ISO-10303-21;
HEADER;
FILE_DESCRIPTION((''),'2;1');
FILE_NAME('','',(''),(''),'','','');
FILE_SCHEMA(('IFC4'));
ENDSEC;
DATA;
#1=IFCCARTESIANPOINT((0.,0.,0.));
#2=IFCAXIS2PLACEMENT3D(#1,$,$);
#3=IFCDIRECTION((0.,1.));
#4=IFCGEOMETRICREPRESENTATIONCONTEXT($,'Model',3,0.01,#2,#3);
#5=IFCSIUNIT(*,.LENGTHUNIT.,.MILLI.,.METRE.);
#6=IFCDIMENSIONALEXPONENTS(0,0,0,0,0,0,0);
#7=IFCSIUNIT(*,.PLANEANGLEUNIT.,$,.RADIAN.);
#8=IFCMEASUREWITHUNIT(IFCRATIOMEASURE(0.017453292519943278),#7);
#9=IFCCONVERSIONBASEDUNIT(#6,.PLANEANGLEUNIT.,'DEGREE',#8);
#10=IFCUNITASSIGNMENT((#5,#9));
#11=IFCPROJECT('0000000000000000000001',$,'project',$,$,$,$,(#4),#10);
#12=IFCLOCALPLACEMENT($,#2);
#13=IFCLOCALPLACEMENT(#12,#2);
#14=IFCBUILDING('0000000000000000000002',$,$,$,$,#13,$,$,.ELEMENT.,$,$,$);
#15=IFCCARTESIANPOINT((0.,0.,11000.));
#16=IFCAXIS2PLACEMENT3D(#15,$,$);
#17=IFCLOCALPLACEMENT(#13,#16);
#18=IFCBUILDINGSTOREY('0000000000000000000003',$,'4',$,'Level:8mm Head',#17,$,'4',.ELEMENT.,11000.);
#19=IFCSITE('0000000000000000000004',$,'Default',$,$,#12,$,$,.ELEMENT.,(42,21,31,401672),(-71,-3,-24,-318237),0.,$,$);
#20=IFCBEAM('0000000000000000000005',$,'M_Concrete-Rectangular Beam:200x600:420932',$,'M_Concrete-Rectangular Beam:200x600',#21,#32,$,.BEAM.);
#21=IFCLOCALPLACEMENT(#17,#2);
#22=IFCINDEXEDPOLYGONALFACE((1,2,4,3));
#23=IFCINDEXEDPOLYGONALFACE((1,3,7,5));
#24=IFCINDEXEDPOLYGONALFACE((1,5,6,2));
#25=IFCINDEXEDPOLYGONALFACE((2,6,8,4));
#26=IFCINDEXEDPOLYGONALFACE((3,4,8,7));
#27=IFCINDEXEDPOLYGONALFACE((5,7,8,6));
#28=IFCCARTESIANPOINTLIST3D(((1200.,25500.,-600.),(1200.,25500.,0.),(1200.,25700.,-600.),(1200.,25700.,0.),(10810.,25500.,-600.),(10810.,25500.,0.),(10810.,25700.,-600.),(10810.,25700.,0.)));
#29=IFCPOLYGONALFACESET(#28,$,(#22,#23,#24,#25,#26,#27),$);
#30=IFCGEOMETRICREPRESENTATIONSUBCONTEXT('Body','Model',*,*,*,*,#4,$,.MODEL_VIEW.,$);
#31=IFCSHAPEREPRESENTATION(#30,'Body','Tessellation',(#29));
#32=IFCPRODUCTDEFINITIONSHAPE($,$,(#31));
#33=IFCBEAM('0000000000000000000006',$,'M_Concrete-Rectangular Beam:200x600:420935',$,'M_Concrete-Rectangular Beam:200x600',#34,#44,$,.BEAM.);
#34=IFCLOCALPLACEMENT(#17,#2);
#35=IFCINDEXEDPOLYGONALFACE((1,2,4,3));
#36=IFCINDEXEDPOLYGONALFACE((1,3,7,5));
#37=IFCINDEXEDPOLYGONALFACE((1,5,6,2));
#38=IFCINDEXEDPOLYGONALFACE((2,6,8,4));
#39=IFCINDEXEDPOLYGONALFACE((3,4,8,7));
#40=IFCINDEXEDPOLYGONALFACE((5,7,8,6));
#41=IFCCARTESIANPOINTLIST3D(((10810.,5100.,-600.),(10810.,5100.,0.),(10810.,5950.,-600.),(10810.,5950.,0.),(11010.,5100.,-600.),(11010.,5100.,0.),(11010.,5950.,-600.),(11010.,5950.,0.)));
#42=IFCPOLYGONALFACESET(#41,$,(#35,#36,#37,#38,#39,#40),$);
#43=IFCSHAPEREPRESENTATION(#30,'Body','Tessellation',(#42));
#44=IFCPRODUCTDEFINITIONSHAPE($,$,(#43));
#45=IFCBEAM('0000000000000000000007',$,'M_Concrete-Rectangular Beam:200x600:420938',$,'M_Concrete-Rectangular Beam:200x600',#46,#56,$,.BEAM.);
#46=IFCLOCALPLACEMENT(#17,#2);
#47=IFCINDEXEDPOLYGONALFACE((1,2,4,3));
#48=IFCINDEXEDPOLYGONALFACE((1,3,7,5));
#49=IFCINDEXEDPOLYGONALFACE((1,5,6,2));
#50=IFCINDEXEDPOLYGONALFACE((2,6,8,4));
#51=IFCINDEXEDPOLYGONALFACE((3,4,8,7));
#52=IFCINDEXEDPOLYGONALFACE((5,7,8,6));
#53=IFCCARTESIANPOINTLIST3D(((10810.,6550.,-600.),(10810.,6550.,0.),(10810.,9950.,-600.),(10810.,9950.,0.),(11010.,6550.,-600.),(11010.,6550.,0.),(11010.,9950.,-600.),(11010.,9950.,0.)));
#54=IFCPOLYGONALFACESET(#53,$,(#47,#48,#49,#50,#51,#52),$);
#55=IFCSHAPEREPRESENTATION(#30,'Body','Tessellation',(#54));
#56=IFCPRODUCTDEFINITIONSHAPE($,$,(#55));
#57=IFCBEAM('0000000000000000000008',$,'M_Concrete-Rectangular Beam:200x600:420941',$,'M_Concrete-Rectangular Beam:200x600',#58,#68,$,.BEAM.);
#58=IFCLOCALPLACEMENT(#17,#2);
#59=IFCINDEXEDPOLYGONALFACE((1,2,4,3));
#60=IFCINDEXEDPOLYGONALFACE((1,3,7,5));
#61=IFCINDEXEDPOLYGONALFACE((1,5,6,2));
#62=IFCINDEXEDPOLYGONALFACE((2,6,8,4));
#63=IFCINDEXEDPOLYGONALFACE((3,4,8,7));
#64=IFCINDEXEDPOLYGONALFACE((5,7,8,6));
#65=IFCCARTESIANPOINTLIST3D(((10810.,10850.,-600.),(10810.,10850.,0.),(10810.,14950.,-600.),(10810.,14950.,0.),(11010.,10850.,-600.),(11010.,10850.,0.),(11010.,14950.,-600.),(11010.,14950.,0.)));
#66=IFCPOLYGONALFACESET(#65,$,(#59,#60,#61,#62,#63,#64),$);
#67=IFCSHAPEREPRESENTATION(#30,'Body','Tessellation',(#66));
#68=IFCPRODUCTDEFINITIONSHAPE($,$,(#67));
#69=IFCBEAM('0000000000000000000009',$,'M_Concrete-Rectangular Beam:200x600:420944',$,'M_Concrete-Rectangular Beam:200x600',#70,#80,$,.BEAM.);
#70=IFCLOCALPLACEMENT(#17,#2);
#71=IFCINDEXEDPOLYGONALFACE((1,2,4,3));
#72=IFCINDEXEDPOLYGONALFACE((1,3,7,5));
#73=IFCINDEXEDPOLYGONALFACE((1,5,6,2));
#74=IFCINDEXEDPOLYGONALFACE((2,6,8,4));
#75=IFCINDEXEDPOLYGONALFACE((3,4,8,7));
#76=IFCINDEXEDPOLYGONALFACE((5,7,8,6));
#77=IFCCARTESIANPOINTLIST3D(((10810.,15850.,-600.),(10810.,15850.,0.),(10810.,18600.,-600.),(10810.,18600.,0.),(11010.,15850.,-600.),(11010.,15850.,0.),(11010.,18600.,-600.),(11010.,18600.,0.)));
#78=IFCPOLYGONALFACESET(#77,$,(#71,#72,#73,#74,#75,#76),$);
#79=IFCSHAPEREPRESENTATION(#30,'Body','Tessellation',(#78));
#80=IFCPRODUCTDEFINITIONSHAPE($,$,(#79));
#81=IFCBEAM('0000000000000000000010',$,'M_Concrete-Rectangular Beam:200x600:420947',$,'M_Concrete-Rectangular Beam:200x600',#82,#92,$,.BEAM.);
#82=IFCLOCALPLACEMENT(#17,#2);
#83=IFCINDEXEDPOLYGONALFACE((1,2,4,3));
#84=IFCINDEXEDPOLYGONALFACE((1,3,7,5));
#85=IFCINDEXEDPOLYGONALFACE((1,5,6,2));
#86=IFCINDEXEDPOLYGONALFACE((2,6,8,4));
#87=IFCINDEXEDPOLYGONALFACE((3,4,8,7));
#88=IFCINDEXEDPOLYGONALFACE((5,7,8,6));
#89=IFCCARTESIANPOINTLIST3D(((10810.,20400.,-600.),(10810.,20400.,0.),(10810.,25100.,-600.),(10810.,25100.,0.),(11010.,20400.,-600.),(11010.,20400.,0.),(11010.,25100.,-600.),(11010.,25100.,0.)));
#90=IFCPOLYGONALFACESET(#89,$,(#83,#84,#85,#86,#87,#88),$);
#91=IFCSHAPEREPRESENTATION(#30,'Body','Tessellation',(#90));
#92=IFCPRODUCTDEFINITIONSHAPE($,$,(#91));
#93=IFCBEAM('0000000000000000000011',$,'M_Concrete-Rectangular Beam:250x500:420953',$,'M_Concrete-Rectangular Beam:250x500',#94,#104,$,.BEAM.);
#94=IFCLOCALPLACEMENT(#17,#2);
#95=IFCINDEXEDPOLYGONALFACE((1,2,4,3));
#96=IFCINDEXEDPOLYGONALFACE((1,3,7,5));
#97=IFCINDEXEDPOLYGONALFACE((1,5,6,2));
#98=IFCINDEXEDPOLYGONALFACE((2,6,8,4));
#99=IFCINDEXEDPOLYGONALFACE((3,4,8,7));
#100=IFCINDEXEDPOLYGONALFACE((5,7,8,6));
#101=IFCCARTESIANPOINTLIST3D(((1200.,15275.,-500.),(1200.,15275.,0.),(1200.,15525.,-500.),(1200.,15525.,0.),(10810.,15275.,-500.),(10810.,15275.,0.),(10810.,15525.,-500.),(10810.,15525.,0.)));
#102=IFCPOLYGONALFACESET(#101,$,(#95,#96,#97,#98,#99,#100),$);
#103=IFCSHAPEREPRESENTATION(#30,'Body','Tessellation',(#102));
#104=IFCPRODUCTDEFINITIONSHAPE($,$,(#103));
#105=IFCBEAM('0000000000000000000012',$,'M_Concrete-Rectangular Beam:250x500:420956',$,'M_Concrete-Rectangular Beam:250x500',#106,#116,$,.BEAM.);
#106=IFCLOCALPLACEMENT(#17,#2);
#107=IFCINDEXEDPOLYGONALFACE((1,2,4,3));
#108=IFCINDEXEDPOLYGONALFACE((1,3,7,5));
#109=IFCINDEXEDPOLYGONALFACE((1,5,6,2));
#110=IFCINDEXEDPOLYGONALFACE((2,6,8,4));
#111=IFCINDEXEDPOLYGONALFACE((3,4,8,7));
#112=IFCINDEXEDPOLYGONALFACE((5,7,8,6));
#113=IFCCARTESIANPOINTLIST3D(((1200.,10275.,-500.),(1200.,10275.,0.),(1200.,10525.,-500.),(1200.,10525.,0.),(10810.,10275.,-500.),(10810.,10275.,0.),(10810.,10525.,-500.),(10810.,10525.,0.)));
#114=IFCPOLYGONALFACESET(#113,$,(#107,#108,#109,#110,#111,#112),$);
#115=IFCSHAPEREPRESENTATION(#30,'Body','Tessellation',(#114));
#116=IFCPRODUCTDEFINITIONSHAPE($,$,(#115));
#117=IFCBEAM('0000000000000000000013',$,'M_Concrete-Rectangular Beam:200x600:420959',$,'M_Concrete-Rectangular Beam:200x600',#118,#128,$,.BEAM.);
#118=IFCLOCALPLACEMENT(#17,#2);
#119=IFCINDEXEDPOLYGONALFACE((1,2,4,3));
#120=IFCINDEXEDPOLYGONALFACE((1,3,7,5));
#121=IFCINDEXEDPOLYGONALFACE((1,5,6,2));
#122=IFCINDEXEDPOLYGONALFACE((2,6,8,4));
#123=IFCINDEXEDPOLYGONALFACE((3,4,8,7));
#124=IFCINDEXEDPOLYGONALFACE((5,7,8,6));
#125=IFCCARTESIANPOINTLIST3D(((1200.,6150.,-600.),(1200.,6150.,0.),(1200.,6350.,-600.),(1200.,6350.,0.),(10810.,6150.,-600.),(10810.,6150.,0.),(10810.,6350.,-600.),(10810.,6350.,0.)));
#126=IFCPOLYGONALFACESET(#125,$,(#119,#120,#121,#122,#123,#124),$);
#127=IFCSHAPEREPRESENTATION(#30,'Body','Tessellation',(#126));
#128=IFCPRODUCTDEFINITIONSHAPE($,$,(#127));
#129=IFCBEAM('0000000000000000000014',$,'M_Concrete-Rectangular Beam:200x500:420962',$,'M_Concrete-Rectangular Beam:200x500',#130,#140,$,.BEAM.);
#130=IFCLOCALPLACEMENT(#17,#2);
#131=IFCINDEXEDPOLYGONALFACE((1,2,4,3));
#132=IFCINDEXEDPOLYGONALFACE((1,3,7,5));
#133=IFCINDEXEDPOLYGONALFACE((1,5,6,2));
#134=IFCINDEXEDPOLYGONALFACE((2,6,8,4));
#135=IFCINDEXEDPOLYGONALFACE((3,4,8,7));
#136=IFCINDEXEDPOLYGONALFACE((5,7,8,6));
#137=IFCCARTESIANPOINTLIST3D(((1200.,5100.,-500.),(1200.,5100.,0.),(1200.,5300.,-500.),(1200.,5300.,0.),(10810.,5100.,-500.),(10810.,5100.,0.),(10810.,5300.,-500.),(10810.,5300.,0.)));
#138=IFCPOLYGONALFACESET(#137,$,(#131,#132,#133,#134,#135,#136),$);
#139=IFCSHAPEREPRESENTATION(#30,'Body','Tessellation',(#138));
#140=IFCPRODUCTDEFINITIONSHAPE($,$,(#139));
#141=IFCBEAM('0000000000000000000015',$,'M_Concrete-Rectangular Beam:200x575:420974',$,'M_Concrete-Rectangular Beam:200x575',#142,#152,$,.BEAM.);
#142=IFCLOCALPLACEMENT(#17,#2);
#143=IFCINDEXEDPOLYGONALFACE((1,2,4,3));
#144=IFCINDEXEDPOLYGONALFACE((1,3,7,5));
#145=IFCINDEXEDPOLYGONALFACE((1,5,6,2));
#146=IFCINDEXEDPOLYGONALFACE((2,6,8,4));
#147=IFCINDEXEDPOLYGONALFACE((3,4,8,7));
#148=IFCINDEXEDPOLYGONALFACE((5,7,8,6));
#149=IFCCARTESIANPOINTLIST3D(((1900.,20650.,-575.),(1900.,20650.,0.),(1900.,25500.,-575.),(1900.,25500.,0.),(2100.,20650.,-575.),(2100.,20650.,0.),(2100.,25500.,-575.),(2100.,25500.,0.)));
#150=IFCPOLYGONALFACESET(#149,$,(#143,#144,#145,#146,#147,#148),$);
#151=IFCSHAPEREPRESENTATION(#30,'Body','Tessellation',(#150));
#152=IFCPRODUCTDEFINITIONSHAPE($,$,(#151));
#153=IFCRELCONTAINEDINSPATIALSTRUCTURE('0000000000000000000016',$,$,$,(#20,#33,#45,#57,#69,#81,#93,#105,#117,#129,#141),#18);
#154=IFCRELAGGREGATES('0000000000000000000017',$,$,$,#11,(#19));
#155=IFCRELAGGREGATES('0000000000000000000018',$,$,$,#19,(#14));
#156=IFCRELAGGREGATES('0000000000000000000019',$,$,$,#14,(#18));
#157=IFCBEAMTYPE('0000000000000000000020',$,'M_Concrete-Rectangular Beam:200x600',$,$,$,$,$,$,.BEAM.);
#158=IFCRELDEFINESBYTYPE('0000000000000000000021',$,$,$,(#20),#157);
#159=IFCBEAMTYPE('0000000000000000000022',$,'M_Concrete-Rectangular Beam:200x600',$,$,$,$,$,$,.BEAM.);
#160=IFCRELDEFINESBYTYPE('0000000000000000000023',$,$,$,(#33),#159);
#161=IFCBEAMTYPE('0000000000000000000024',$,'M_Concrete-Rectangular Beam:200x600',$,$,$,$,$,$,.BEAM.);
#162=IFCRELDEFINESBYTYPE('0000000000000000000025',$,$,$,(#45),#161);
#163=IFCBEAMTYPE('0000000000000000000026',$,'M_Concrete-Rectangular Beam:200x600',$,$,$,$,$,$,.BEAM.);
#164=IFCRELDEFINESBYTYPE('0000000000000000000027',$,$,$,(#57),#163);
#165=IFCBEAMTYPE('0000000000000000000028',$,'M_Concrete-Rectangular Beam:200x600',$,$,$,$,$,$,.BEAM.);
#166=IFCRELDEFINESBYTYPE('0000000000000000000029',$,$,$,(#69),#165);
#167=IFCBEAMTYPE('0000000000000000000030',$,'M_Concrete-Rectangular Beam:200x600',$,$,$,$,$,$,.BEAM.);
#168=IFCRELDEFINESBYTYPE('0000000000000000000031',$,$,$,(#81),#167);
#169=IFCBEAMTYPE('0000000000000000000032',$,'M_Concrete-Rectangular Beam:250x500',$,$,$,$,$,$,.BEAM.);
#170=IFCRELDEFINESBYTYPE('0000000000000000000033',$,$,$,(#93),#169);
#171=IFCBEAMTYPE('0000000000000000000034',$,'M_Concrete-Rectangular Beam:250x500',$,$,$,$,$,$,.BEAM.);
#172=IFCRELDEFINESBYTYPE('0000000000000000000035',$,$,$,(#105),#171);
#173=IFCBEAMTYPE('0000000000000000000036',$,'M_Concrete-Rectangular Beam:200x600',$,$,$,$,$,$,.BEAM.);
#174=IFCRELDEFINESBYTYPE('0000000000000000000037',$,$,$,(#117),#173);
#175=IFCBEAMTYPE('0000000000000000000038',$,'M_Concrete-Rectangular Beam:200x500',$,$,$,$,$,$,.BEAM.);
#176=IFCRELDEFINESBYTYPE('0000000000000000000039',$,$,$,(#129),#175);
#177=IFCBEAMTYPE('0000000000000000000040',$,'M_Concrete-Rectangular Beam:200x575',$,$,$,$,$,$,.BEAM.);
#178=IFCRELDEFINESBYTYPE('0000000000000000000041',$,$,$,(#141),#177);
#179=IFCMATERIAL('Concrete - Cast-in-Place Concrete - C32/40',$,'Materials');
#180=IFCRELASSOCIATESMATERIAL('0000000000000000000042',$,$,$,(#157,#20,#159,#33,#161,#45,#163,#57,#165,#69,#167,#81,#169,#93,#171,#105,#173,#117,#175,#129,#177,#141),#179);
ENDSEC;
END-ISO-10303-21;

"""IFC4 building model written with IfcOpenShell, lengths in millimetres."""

from ifc_helpers import new_model, entity, si_unit, converted_unit, direction, frame, origin, place, context, subcontext, project, spatial, indexed_curve, outline, extrude, source, transform, mapped, material, type_object, type_shapes, element, save


model = new_model("IFC4")

# Units and contexts
model_context = context("Model", 3, precision=0.01, world=origin(), true_north=direction((0.0, 1.0)))
body_context = subcontext(model_context, "Body", "Model", "MODEL_VIEW")
ifc_project = project(units=[si_unit("LENGTHUNIT", "METRE", prefix="MILLI"), converted_unit("PLANEANGLEUNIT", "DEGREE", entity("IfcRatioMeasure", 0.017453292519943278), si_unit("PLANEANGLEUNIT", "RADIAN"), dimensions=[0, 0, 0, 0, 0, 0, 0])], contexts=[model_context])

# Site, building, storey
site_placement = place(None, origin())
site = spatial("IfcSite", under=ifc_project, at=site_placement, Name="Default", CompositionType="ELEMENT", RefLatitude=(42, 21, 31, 401672), RefLongitude=(-71, -3, -24, -318237), RefElevation=0.0)
building_placement = place(site_placement, origin())
building = spatial("IfcBuilding", under=site, at=building_placement, CompositionType="ELEMENT")
storey_placement = place(building_placement, frame((0.0, 0.0, 11000.0)))
storey = spatial("IfcBuildingStorey", under=building, at=storey_placement, Name="4", ObjectType="Level:8mm Head", LongName="4", CompositionType="ELEMENT", Elevation=11000.0)

# Beams
ifc_material_1 = material(Name="Concrete - Cast-in-Place Concrete - C32/40", Category="Materials")
beam_type_1 = type_object("IfcBeamType", Name="M_Concrete-Rectangular Beam:200x600", PredefinedType="BEAM", material=ifc_material_1)
shared_shape_1 = source(origin(), body_context, "Body", "SweptSolid", [
    extrude(outline(indexed_curve([(-300.0, -100.0), (300.0, -100.0), (300.0, 100.0), (-300.0, 100.0), (-300.0, -100.0)], self_intersect=False)), frame((1200.0, 25600.0, 10700.0), z_axis=(1.0, 0.0, 0.0), x_axis=(0.0, 0.0, -1.0)), (0.0, 0.0, 1.0), 9610.0),
])
type_shapes(beam_type_1, [shared_shape_1])
beam_1_placement = place(storey_placement, frame((0.0, 0.0, -11000.0)))
element("IfcBeam", 1, at=beam_1_placement, inside=storey, type_object=beam_type_1, material=ifc_material_1, Name="M_Concrete-Rectangular Beam:200x600:420932", ObjectType="M_Concrete-Rectangular Beam:200x600", PredefinedType="BEAM", context=body_context, shape_type="MappedRepresentation", body=[
    mapped(shared_shape_1, transform((0.0, 0.0, 0.0), scale=1.0)),
])
beam_type_2 = type_object("IfcBeamType", Name="M_Concrete-Rectangular Beam:200x600", PredefinedType="BEAM", material=ifc_material_1)
shared_shape_2 = source(origin(), body_context, "Body", "SweptSolid", [
    extrude(outline(indexed_curve([(-100.0, -300.0), (100.0, -300.0), (100.0, 300.0), (-100.0, 300.0), (-100.0, -300.0)], self_intersect=False)), frame((10910.0, 5100.0, 10700.0), z_axis=(0.0, 1.0, 0.0), x_axis=(-1.0, 0.0, 0.0)), (0.0, 0.0, 1.0), 850.0),
])
type_shapes(beam_type_2, [shared_shape_2])
beam_2_placement = place(storey_placement, frame((0.0, 0.0, -11000.0)))
element("IfcBeam", 2, at=beam_2_placement, inside=storey, type_object=beam_type_2, material=ifc_material_1, Name="M_Concrete-Rectangular Beam:200x600:420935", ObjectType="M_Concrete-Rectangular Beam:200x600", PredefinedType="BEAM", context=body_context, shape_type="MappedRepresentation", body=[
    mapped(shared_shape_2, transform((0.0, 0.0, 0.0), scale=1.0)),
])
beam_type_3 = type_object("IfcBeamType", Name="M_Concrete-Rectangular Beam:200x600", PredefinedType="BEAM", material=ifc_material_1)
shared_shape_3 = source(origin(), body_context, "Body", "SweptSolid", [
    extrude(outline(indexed_curve([(-100.0, -300.0), (100.0, -300.0), (100.0, 300.0), (-100.0, 300.0), (-100.0, -300.0)], self_intersect=False)), frame((10910.0, 6550.0, 10700.0), z_axis=(0.0, 1.0, 0.0), x_axis=(-1.0, 0.0, 0.0)), (0.0, 0.0, 1.0), 3400.0),
])
type_shapes(beam_type_3, [shared_shape_3])
beam_3_placement = place(storey_placement, frame((0.0, 0.0, -11000.0)))
element("IfcBeam", 3, at=beam_3_placement, inside=storey, type_object=beam_type_3, material=ifc_material_1, Name="M_Concrete-Rectangular Beam:200x600:420938", ObjectType="M_Concrete-Rectangular Beam:200x600", PredefinedType="BEAM", context=body_context, shape_type="MappedRepresentation", body=[
    mapped(shared_shape_3, transform((0.0, 0.0, 0.0), scale=1.0)),
])
beam_type_4 = type_object("IfcBeamType", Name="M_Concrete-Rectangular Beam:200x600", PredefinedType="BEAM", material=ifc_material_1)
shared_shape_4 = source(origin(), body_context, "Body", "SweptSolid", [
    extrude(outline(indexed_curve([(-100.0, -300.0), (100.0, -300.0), (100.0, 300.0), (-100.0, 300.0), (-100.0, -300.0)], self_intersect=False)), frame((10910.0, 10850.0, 10700.0), z_axis=(0.0, 1.0, 0.0), x_axis=(-1.0, 0.0, 0.0)), (0.0, 0.0, 1.0), 4100.0),
])
type_shapes(beam_type_4, [shared_shape_4])
beam_4_placement = place(storey_placement, frame((0.0, 0.0, -11000.0)))
element("IfcBeam", 4, at=beam_4_placement, inside=storey, type_object=beam_type_4, material=ifc_material_1, Name="M_Concrete-Rectangular Beam:200x600:420941", ObjectType="M_Concrete-Rectangular Beam:200x600", PredefinedType="BEAM", context=body_context, shape_type="MappedRepresentation", body=[
    mapped(shared_shape_4, transform((0.0, 0.0, 0.0), scale=1.0)),
])
beam_type_5 = type_object("IfcBeamType", Name="M_Concrete-Rectangular Beam:200x600", PredefinedType="BEAM", material=ifc_material_1)
shared_shape_5 = source(origin(), body_context, "Body", "SweptSolid", [
    extrude(outline(indexed_curve([(-100.0, -300.0), (100.0, -300.0), (100.0, 300.0), (-100.0, 300.0), (-100.0, -300.0)], self_intersect=False)), frame((10910.0, 15850.0, 10700.0), z_axis=(0.0, 1.0, 0.0), x_axis=(-1.0, 0.0, 0.0)), (0.0, 0.0, 1.0), 2750.0),
])
type_shapes(beam_type_5, [shared_shape_5])
beam_5_placement = place(storey_placement, frame((0.0, 0.0, -11000.0)))
element("IfcBeam", 5, at=beam_5_placement, inside=storey, type_object=beam_type_5, material=ifc_material_1, Name="M_Concrete-Rectangular Beam:200x600:420944", ObjectType="M_Concrete-Rectangular Beam:200x600", PredefinedType="BEAM", context=body_context, shape_type="MappedRepresentation", body=[
    mapped(shared_shape_5, transform((0.0, 0.0, 0.0), scale=1.0)),
])
beam_type_6 = type_object("IfcBeamType", Name="M_Concrete-Rectangular Beam:200x600", PredefinedType="BEAM", material=ifc_material_1)
shared_shape_6 = source(origin(), body_context, "Body", "SweptSolid", [
    extrude(outline(indexed_curve([(-100.0, -300.0), (100.0, -300.0), (100.0, 300.0), (-100.0, 300.0), (-100.0, -300.0)], self_intersect=False)), frame((10910.0, 20400.0, 10700.0), z_axis=(0.0, 1.0, 0.0), x_axis=(-1.0, 0.0, 0.0)), (0.0, 0.0, 1.0), 4700.0),
])
type_shapes(beam_type_6, [shared_shape_6])
beam_6_placement = place(storey_placement, frame((0.0, 0.0, -11000.0)))
element("IfcBeam", 6, at=beam_6_placement, inside=storey, type_object=beam_type_6, material=ifc_material_1, Name="M_Concrete-Rectangular Beam:200x600:420947", ObjectType="M_Concrete-Rectangular Beam:200x600", PredefinedType="BEAM", context=body_context, shape_type="MappedRepresentation", body=[
    mapped(shared_shape_6, transform((0.0, 0.0, 0.0), scale=1.0)),
])
beam_type_7 = type_object("IfcBeamType", Name="M_Concrete-Rectangular Beam:250x500", PredefinedType="BEAM", material=ifc_material_1)
shared_shape_7 = source(origin(), body_context, "Body", "SweptSolid", [
    extrude(outline(indexed_curve([(-250.0, -125.0), (250.0, -125.0), (250.0, 125.0), (-250.0, 125.0), (-250.0, -125.0)], self_intersect=False)), frame((1200.0, 15400.0, 10750.0), z_axis=(1.0, 0.0, 0.0), x_axis=(0.0, 0.0, -1.0)), (0.0, 0.0, 1.0), 9610.0),
])
type_shapes(beam_type_7, [shared_shape_7])
beam_7_placement = place(storey_placement, frame((0.0, 0.0, -11000.0)))
element("IfcBeam", 7, at=beam_7_placement, inside=storey, type_object=beam_type_7, material=ifc_material_1, Name="M_Concrete-Rectangular Beam:250x500:420953", ObjectType="M_Concrete-Rectangular Beam:250x500", PredefinedType="BEAM", context=body_context, shape_type="MappedRepresentation", body=[
    mapped(shared_shape_7, transform((0.0, 0.0, 0.0), scale=1.0)),
])
beam_type_8 = type_object("IfcBeamType", Name="M_Concrete-Rectangular Beam:250x500", PredefinedType="BEAM", material=ifc_material_1)
shared_shape_8 = source(origin(), body_context, "Body", "SweptSolid", [
    extrude(outline(indexed_curve([(-250.0, -125.0), (250.0, -125.0), (250.0, 125.0), (-250.0, 125.0), (-250.0, -125.0)], self_intersect=False)), frame((1200.0, 10400.0, 10750.0), z_axis=(1.0, 0.0, 0.0), x_axis=(0.0, 0.0, -1.0)), (0.0, 0.0, 1.0), 9610.0),
])
type_shapes(beam_type_8, [shared_shape_8])
beam_8_placement = place(storey_placement, frame((0.0, 0.0, -11000.0)))
element("IfcBeam", 8, at=beam_8_placement, inside=storey, type_object=beam_type_8, material=ifc_material_1, Name="M_Concrete-Rectangular Beam:250x500:420956", ObjectType="M_Concrete-Rectangular Beam:250x500", PredefinedType="BEAM", context=body_context, shape_type="MappedRepresentation", body=[
    mapped(shared_shape_8, transform((0.0, 0.0, 0.0), scale=1.0)),
])
beam_type_9 = type_object("IfcBeamType", Name="M_Concrete-Rectangular Beam:200x600", PredefinedType="BEAM", material=ifc_material_1)
shared_shape_9 = source(origin(), body_context, "Body", "SweptSolid", [
    extrude(outline(indexed_curve([(-300.0, -100.0), (300.0, -100.0), (300.0, 100.0), (-300.0, 100.0), (-300.0, -100.0)], self_intersect=False)), frame((1200.0, 6250.0, 10700.0), z_axis=(1.0, 0.0, 0.0), x_axis=(0.0, 0.0, -1.0)), (0.0, 0.0, 1.0), 9610.0),
])
type_shapes(beam_type_9, [shared_shape_9])
beam_9_placement = place(storey_placement, frame((0.0, 0.0, -11000.0)))
element("IfcBeam", 9, at=beam_9_placement, inside=storey, type_object=beam_type_9, material=ifc_material_1, Name="M_Concrete-Rectangular Beam:200x600:420959", ObjectType="M_Concrete-Rectangular Beam:200x600", PredefinedType="BEAM", context=body_context, shape_type="MappedRepresentation", body=[
    mapped(shared_shape_9, transform((0.0, 0.0, 0.0), scale=1.0)),
])
beam_type_10 = type_object("IfcBeamType", Name="M_Concrete-Rectangular Beam:200x500", PredefinedType="BEAM", material=ifc_material_1)
shared_shape_10 = source(origin(), body_context, "Body", "SweptSolid", [
    extrude(outline(indexed_curve([(-250.0, -100.0), (250.0, -100.0), (250.0, 100.0), (-250.0, 100.0), (-250.0, -100.0)], self_intersect=False)), frame((1200.0, 5200.0, 10750.0), z_axis=(1.0, 0.0, 0.0), x_axis=(0.0, 0.0, -1.0)), (0.0, 0.0, 1.0), 9610.0),
])
type_shapes(beam_type_10, [shared_shape_10])
beam_10_placement = place(storey_placement, frame((0.0, 0.0, -11000.0)))
element("IfcBeam", 10, at=beam_10_placement, inside=storey, type_object=beam_type_10, material=ifc_material_1, Name="M_Concrete-Rectangular Beam:200x500:420962", ObjectType="M_Concrete-Rectangular Beam:200x500", PredefinedType="BEAM", context=body_context, shape_type="MappedRepresentation", body=[
    mapped(shared_shape_10, transform((0.0, 0.0, 0.0), scale=1.0)),
])
beam_type_11 = type_object("IfcBeamType", Name="M_Concrete-Rectangular Beam:200x575", PredefinedType="BEAM", material=ifc_material_1)
shared_shape_11 = source(origin(), body_context, "Body", "SweptSolid", [
    extrude(outline(indexed_curve([(-100.0, -287.5), (100.0, -287.5), (100.0, 287.5), (-100.0, 287.5), (-100.0, -287.5)], self_intersect=False)), frame((2000.0, 20650.0, 10712.5), z_axis=(0.0, 1.0, 0.0), x_axis=(-1.0, 0.0, 0.0)), (0.0, 0.0, 1.0), 4850.0),
])
type_shapes(beam_type_11, [shared_shape_11])
beam_11_placement = place(storey_placement, frame((0.0, 0.0, -11000.0)))
element("IfcBeam", 11, at=beam_11_placement, inside=storey, type_object=beam_type_11, material=ifc_material_1, Name="M_Concrete-Rectangular Beam:200x575:420974", ObjectType="M_Concrete-Rectangular Beam:200x575", PredefinedType="BEAM", context=body_context, shape_type="MappedRepresentation", body=[
    mapped(shared_shape_11, transform((0.0, 0.0, 0.0), scale=1.0)),
])

save(model, "model.ifc")
